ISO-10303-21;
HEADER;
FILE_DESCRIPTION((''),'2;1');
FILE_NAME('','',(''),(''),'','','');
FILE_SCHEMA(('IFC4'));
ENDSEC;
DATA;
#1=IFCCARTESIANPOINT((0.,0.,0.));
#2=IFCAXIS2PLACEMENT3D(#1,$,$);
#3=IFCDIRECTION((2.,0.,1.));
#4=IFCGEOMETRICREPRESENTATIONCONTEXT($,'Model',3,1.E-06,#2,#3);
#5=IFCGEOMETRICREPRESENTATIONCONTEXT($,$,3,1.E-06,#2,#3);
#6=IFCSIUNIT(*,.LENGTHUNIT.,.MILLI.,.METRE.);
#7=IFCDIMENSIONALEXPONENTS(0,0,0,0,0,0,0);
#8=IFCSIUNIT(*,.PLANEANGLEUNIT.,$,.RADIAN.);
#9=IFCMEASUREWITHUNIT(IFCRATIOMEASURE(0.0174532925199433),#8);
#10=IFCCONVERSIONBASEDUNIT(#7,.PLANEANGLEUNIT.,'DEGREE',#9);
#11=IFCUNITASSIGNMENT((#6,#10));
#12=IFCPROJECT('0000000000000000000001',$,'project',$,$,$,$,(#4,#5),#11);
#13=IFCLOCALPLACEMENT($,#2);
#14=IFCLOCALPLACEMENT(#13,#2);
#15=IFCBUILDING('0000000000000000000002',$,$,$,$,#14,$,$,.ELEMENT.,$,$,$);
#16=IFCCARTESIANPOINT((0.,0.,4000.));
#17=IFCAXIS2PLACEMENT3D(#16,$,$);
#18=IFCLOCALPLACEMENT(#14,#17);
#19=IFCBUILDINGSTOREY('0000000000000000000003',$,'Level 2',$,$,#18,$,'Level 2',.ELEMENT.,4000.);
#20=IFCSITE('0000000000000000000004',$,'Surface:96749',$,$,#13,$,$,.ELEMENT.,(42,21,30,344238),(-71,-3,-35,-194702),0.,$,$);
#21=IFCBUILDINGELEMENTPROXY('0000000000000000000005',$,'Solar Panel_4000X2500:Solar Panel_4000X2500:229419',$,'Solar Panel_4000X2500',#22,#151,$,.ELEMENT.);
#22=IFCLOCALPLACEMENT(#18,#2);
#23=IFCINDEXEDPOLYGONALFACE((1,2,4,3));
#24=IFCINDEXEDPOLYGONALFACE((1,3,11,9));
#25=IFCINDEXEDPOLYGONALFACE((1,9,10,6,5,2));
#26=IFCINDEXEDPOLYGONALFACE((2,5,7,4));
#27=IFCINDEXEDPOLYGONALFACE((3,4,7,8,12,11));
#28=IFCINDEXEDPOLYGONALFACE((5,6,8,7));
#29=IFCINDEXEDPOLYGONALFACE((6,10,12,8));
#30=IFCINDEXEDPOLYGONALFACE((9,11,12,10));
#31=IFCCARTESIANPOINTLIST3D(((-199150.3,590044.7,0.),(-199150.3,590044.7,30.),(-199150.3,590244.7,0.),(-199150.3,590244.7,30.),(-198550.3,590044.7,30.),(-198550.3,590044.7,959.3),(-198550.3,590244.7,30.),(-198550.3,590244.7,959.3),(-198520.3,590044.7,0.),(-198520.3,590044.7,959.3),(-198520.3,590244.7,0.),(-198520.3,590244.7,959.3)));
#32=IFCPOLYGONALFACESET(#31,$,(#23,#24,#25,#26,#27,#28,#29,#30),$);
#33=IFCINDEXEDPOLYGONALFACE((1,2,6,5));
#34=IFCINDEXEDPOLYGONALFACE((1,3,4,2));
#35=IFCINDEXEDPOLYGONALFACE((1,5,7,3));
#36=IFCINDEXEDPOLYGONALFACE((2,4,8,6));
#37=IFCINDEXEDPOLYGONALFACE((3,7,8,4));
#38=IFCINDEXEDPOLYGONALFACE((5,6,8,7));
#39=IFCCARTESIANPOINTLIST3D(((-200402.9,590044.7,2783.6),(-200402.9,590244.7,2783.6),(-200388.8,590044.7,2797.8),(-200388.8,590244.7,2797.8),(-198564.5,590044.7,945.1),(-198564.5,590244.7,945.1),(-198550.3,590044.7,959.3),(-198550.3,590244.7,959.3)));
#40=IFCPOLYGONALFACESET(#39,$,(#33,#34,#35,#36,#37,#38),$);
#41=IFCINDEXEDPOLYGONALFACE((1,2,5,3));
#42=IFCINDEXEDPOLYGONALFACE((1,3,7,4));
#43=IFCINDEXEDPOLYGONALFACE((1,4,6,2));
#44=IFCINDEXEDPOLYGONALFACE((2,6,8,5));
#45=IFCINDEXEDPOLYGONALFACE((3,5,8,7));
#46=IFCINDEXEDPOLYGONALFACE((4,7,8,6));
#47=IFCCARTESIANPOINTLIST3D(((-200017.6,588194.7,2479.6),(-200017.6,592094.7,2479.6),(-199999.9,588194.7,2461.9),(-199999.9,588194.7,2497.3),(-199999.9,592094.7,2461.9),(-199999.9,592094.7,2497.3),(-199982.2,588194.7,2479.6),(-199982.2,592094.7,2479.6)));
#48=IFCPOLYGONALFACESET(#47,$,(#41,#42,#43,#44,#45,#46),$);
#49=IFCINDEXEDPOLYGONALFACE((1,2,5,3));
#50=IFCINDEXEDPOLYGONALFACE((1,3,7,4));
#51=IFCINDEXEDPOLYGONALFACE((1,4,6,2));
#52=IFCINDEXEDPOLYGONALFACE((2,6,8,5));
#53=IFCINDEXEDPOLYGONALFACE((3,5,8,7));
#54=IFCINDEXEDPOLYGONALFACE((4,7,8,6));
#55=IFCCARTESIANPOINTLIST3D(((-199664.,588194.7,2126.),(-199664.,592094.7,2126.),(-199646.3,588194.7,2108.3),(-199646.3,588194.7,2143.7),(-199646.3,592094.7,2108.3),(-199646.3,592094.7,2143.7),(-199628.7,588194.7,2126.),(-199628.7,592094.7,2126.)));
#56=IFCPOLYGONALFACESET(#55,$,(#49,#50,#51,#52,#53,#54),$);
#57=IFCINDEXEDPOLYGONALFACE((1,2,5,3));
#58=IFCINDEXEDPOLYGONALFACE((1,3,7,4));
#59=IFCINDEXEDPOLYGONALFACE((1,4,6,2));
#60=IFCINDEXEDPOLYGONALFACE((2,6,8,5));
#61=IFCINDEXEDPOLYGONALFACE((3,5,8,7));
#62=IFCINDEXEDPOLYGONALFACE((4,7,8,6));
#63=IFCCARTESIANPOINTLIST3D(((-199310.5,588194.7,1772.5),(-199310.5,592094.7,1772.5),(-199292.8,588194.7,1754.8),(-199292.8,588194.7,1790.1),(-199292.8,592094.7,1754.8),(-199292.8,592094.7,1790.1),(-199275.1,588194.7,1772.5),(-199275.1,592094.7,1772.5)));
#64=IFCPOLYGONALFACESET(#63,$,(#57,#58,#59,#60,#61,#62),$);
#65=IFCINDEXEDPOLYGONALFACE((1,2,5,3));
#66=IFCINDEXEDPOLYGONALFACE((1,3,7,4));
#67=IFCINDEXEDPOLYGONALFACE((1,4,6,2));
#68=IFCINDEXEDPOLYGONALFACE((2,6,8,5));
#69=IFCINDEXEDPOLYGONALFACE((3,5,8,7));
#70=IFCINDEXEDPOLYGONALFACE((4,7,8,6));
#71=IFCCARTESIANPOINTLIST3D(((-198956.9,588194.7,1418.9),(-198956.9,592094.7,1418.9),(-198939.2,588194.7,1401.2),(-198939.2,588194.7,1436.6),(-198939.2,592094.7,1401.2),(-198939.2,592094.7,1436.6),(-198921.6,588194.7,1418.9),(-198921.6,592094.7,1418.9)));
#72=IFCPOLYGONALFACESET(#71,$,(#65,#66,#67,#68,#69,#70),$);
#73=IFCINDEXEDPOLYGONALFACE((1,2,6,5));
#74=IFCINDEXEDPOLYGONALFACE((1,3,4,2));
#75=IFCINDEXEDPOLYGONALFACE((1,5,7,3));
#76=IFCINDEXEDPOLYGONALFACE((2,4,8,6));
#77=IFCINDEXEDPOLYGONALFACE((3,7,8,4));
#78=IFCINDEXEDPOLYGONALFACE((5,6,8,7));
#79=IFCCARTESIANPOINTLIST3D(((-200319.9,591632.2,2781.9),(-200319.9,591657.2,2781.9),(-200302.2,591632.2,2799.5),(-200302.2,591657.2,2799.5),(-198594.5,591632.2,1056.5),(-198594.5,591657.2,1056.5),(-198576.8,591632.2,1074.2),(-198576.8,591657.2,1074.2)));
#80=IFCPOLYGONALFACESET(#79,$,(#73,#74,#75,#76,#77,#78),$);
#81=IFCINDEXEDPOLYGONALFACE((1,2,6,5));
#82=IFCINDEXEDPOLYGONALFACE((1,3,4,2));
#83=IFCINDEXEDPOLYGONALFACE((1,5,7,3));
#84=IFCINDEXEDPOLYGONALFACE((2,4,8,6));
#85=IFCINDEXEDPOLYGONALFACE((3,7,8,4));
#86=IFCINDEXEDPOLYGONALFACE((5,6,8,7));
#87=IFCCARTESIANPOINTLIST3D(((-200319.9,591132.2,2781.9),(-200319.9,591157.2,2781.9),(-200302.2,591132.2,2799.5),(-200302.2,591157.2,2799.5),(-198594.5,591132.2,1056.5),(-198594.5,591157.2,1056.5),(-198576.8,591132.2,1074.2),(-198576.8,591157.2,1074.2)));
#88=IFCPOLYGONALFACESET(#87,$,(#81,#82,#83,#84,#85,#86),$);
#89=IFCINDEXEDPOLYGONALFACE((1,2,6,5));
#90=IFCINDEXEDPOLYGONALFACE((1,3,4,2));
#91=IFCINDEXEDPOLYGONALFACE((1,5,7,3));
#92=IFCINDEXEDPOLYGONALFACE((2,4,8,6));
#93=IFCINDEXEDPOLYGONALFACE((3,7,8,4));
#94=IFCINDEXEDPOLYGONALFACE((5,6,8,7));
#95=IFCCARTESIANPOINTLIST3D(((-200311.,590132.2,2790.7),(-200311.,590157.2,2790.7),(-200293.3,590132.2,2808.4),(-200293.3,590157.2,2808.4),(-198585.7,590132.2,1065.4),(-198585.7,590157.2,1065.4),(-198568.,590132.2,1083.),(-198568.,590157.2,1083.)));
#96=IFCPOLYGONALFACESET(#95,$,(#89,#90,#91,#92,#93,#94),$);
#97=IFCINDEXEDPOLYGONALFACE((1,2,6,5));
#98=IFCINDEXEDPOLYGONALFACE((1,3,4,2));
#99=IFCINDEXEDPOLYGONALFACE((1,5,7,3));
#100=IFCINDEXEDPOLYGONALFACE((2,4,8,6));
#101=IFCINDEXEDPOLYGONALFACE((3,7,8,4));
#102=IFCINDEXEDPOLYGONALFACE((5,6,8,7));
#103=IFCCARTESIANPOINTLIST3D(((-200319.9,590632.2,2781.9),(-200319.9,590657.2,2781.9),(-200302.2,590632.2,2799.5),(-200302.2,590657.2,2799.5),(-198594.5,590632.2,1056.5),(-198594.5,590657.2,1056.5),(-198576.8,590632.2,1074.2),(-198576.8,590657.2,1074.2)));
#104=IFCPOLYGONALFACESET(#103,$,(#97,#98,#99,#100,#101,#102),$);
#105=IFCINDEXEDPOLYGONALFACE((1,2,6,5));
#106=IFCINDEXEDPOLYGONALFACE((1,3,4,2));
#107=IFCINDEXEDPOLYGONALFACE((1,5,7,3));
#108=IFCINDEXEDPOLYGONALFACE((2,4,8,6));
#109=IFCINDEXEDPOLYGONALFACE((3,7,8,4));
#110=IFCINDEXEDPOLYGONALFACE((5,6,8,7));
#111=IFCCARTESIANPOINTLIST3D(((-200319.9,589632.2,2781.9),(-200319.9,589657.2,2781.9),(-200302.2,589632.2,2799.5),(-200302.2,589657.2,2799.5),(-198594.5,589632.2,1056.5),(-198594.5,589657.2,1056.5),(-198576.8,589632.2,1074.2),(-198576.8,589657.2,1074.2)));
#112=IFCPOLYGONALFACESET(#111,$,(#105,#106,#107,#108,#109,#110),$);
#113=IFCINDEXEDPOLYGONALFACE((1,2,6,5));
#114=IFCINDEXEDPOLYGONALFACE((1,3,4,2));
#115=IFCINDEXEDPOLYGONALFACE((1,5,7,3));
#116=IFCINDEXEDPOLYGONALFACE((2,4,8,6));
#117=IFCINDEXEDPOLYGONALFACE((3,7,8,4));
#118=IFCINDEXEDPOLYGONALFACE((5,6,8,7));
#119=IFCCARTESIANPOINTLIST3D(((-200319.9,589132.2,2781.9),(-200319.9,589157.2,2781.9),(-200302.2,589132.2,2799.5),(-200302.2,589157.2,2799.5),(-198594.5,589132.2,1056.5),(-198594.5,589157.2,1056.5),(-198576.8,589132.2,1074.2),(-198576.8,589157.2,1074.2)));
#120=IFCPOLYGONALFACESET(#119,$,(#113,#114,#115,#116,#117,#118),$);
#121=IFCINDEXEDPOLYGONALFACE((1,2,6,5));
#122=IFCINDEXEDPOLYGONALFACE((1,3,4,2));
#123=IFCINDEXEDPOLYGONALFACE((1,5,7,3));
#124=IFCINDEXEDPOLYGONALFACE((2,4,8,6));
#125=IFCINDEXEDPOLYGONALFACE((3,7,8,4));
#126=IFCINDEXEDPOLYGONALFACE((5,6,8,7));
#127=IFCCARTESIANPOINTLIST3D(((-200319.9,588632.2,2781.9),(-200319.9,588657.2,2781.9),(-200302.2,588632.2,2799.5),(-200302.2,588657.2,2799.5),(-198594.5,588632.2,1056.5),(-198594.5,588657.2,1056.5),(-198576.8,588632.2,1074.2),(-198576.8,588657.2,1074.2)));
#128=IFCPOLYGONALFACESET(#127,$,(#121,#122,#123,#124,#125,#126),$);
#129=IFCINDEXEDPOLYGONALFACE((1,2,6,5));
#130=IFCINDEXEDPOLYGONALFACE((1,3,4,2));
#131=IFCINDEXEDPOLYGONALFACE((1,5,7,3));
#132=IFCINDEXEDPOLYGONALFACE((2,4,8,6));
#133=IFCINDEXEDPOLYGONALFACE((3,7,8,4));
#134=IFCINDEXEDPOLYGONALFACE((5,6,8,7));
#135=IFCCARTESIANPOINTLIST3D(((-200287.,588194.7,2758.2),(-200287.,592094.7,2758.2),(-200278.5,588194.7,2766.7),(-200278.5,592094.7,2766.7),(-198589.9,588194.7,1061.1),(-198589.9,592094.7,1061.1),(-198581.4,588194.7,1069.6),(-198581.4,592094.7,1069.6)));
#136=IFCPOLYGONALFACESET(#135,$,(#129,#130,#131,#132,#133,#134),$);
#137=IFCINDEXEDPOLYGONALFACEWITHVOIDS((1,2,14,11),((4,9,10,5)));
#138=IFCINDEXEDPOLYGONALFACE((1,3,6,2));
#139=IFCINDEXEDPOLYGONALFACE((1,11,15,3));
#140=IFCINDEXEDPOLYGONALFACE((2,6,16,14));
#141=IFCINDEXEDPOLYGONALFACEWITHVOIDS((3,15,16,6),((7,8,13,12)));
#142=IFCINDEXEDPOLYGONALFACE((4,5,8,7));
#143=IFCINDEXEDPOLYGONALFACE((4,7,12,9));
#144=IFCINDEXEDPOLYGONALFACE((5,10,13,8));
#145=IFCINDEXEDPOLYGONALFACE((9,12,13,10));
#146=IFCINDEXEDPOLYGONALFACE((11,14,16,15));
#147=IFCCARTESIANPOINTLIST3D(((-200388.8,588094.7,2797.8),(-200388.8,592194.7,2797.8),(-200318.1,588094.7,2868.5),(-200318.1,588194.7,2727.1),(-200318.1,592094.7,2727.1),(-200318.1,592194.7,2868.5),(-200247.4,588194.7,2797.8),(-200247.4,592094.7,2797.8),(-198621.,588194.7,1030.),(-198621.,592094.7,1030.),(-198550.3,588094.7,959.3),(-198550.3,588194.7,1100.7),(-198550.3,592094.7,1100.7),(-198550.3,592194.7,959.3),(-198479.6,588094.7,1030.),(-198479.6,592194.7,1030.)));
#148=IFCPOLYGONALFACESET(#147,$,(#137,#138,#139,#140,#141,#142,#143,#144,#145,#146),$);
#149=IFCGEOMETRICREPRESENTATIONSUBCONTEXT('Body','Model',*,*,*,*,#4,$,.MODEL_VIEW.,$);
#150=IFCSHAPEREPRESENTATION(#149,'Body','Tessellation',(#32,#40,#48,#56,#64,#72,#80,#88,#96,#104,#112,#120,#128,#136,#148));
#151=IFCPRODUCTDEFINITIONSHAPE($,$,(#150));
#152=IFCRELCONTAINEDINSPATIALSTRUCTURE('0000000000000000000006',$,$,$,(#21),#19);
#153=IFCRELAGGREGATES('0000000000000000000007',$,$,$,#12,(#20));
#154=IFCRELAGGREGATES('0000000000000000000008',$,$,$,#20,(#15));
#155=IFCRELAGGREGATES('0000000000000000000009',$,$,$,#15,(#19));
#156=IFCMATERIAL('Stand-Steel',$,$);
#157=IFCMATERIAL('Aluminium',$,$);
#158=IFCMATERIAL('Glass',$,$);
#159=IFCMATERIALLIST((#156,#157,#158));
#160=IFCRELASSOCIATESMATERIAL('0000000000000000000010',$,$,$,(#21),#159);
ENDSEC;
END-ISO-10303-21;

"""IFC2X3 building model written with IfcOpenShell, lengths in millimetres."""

from ifc_helpers import new_model, entity, si_unit, converted_unit, direction, frame, frame_2d, origin, origin_2d_with_axis, place, context, subcontext, project, spatial, polyline, rectangle, outline, extrude, source, transform, mapped, material, material_list, element, save


model = new_model("IFC2X3")

# Units and contexts
model_context = context("Model", 3, precision=1e-06, world=origin(), true_north=direction((2.0, 0.0, 1.0)))
context_of_model = context(None, 3, precision=1e-06, world=origin(), true_north=direction((2.0, 0.0, 1.0)))
body_context = subcontext(model_context, "Body", "Model", "MODEL_VIEW")
ifc_project = project(units=[si_unit("LENGTHUNIT", "METRE", prefix="MILLI"), converted_unit("PLANEANGLEUNIT", "DEGREE", entity("IfcRatioMeasure", 0.0174532925199433), si_unit("PLANEANGLEUNIT", "RADIAN"), dimensions=[0, 0, 0, 0, 0, 0, 0])], contexts=[model_context, context_of_model])

# Site, building, storey
site_placement = place(None, origin())
site = spatial("IfcSite", under=ifc_project, at=site_placement, Name="Surface:96749", CompositionType="ELEMENT", RefLatitude=(42, 21, 30, 344238), RefLongitude=(-71, -3, -35, -194702), RefElevation=0.0)
building_placement = place(site_placement, origin())
building = spatial("IfcBuilding", under=site, at=building_placement, CompositionType="ELEMENT")
storey_placement = place(building_placement, frame((0.0, 0.0, 4000.0)))
storey = spatial("IfcBuildingStorey", under=building, at=storey_placement, Name="Level 2", LongName="Level 2", CompositionType="ELEMENT", Elevation=4000.0)

# Building element proxy
ifc_material_1 = material(Name="Stand-Steel")
ifc_material_2 = material(Name="Aluminium")
ifc_material_3 = material(Name="Glass")
shared_shape = source(origin(), body_context, "Body", "SweptSolid", [
    extrude(outline(polyline([(-629.5, -220.0), (329.8, -220.0), (329.8, 410.0), (299.8, 410.0), (299.8, -190.0), (-629.5, -190.0), (-629.5, -220.0)])), frame((-190.0, -100.0, 299.8), z_axis=(0.0, 1.0, 0.0), x_axis=(0.0, 0.0, -1.0)), (0.0, 0.0, 1.0), 200.0),
    extrude(rectangle(XDim=20.0, YDim=200.0, at=frame_2d((0.0, 0.0), x_axis=(0.0, 1.0))), frame((-7.1, 0.0, 922.2), z_axis=(-0.707107, 0.0, 0.707107), x_axis=(0.0, 1.0, 0.0)), (0.0, 0.0, 1.0), 2600.0),
    extrude(rectangle(XDim=25.0, YDim=25.0, at=frame_2d((0.0, 0.0), x_axis=(1.0, 0.0))), frame((-1449.6, -1950.0, 2449.6), z_axis=(0.0, 1.0, 0.0), x_axis=(-0.707107, 0.0, -0.707107)), (0.0, 0.0, 1.0), 3900.0),
    extrude(rectangle(XDim=25.0, YDim=25.0, at=origin_2d_with_axis()), frame((-1096.0, -1950.0, 2096.0), z_axis=(0.0, 1.0, 0.0), x_axis=(-0.707107, 0.0, -0.707107)), (0.0, 0.0, 1.0), 3900.0),
    extrude(rectangle(XDim=25.0, YDim=25.0, at=origin_2d_with_axis()), frame((-742.5, -1950.0, 1742.5), z_axis=(0.0, 1.0, 0.0), x_axis=(-0.707107, 0.0, -0.707107)), (0.0, 0.0, 1.0), 3900.0),
    extrude(rectangle(XDim=25.0, YDim=25.0, at=frame_2d((0.0, 0.0), x_axis=(1.0, 0.0))), frame((-388.9, -1950.0, 1388.9), z_axis=(0.0, 1.0, 0.0), x_axis=(-0.707107, 0.0, -0.707107)), (0.0, 0.0, 1.0), 3900.0),
    extrude(rectangle(XDim=25.0, YDim=25.0, at=frame_2d((0.0, 0.0), x_axis=(0.0, 1.0))), frame((-35.4, 1500.0, 1035.4), z_axis=(-0.707107, 0.0, 0.707107), x_axis=(0.0, 1.0, 0.0)), (0.0, 0.0, 1.0), 2440.0),
    extrude(rectangle(XDim=25.0, YDim=25.0, at=frame_2d((0.0, 0.0), x_axis=(0.0, 1.0))), frame((-35.4, 1000.0, 1035.4), z_axis=(-0.707107, 0.0, 0.707107), x_axis=(0.0, 1.0, 0.0)), (0.0, 0.0, 1.0), 2440.0),
    extrude(rectangle(XDim=25.0, YDim=25.0, at=frame_2d((0.0, 0.0), x_axis=(0.0, 1.0))), frame((-26.5, 0.0, 1044.2), z_axis=(-0.707107, 0.0, 0.707107), x_axis=(0.0, -1.0, 0.0)), (0.0, 0.0, 1.0), 2440.0),
    extrude(rectangle(XDim=25.0, YDim=25.0, at=frame_2d((0.0, 0.0), x_axis=(0.0, 1.0))), frame((-35.4, 500.0, 1035.4), z_axis=(-0.707107, 0.0, 0.707107), x_axis=(0.0, 1.0, 0.0)), (0.0, 0.0, 1.0), 2440.0),
    extrude(rectangle(XDim=25.0, YDim=25.0, at=frame_2d((0.0, 0.0), x_axis=(0.0, 1.0))), frame((-35.4, -500.0, 1035.4), z_axis=(-0.707107, 0.0, 0.707107), x_axis=(0.0, 1.0, 0.0)), (0.0, 0.0, 1.0), 2440.0),
    extrude(rectangle(XDim=25.0, YDim=25.0, at=frame_2d((0.0, 0.0), x_axis=(0.0, 1.0))), frame((-35.4, -1000.0, 1035.4), z_axis=(-0.707107, 0.0, 0.707107), x_axis=(0.0, 1.0, 0.0)), (0.0, 0.0, 1.0), 2440.0),
    extrude(rectangle(XDim=25.0, YDim=25.0, at=frame_2d((0.0, 0.0), x_axis=(0.0, 1.0))), frame((-35.4, -1500.0, 1035.4), z_axis=(-0.707107, 0.0, 0.707107), x_axis=(0.0, 1.0, 0.0)), (0.0, 0.0, 1.0), 2440.0),
    extrude(rectangle(XDim=2400.0, YDim=12.0, at=frame_2d((0.0, 0.0), x_axis=(1.0, 0.0))), frame((-883.9, -1950.0, 1883.9), z_axis=(0.0, 1.0, 0.0), x_axis=(0.707107, 0.0, -0.707107)), (0.0, 0.0, 1.0), 3900.0),
    extrude(outline(polyline([(-2050.0, -1300.0), (2050.0, -1300.0), (2050.0, 1300.0), (-2050.0, 1300.0), (-2050.0, -1300.0)]), holes=[polyline([(1950.0, -1200.0), (-1950.0, -1200.0), (-1950.0, 1200.0), (1950.0, 1200.0), (1950.0, -1200.0)])]), frame((-919.2, 0.0, 1848.5), z_axis=(0.707107, 0.0, 0.707107), x_axis=(0.0, 1.0, 0.0)), (0.0, 0.0, 1.0), 100.0),
])
ifc_material_list_1 = material_list([ifc_material_1, ifc_material_2, ifc_material_3])
proxy_1_placement = place(storey_placement, frame((-198550.3, 590144.7, 30.0)))
element("IfcBuildingElementProxy", 1, at=proxy_1_placement, inside=storey, material=ifc_material_list_1, Name="Solar Panel_4000X2500:Solar Panel_4000X2500:229419", ObjectType="Solar Panel_4000X2500", CompositionType="ELEMENT", context=body_context, shape_type="MappedRepresentation", body=[
    mapped(shared_shape, transform((0.0, 0.0, 0.0), scale=1.0)),
])

save(model, "model.ifc")
